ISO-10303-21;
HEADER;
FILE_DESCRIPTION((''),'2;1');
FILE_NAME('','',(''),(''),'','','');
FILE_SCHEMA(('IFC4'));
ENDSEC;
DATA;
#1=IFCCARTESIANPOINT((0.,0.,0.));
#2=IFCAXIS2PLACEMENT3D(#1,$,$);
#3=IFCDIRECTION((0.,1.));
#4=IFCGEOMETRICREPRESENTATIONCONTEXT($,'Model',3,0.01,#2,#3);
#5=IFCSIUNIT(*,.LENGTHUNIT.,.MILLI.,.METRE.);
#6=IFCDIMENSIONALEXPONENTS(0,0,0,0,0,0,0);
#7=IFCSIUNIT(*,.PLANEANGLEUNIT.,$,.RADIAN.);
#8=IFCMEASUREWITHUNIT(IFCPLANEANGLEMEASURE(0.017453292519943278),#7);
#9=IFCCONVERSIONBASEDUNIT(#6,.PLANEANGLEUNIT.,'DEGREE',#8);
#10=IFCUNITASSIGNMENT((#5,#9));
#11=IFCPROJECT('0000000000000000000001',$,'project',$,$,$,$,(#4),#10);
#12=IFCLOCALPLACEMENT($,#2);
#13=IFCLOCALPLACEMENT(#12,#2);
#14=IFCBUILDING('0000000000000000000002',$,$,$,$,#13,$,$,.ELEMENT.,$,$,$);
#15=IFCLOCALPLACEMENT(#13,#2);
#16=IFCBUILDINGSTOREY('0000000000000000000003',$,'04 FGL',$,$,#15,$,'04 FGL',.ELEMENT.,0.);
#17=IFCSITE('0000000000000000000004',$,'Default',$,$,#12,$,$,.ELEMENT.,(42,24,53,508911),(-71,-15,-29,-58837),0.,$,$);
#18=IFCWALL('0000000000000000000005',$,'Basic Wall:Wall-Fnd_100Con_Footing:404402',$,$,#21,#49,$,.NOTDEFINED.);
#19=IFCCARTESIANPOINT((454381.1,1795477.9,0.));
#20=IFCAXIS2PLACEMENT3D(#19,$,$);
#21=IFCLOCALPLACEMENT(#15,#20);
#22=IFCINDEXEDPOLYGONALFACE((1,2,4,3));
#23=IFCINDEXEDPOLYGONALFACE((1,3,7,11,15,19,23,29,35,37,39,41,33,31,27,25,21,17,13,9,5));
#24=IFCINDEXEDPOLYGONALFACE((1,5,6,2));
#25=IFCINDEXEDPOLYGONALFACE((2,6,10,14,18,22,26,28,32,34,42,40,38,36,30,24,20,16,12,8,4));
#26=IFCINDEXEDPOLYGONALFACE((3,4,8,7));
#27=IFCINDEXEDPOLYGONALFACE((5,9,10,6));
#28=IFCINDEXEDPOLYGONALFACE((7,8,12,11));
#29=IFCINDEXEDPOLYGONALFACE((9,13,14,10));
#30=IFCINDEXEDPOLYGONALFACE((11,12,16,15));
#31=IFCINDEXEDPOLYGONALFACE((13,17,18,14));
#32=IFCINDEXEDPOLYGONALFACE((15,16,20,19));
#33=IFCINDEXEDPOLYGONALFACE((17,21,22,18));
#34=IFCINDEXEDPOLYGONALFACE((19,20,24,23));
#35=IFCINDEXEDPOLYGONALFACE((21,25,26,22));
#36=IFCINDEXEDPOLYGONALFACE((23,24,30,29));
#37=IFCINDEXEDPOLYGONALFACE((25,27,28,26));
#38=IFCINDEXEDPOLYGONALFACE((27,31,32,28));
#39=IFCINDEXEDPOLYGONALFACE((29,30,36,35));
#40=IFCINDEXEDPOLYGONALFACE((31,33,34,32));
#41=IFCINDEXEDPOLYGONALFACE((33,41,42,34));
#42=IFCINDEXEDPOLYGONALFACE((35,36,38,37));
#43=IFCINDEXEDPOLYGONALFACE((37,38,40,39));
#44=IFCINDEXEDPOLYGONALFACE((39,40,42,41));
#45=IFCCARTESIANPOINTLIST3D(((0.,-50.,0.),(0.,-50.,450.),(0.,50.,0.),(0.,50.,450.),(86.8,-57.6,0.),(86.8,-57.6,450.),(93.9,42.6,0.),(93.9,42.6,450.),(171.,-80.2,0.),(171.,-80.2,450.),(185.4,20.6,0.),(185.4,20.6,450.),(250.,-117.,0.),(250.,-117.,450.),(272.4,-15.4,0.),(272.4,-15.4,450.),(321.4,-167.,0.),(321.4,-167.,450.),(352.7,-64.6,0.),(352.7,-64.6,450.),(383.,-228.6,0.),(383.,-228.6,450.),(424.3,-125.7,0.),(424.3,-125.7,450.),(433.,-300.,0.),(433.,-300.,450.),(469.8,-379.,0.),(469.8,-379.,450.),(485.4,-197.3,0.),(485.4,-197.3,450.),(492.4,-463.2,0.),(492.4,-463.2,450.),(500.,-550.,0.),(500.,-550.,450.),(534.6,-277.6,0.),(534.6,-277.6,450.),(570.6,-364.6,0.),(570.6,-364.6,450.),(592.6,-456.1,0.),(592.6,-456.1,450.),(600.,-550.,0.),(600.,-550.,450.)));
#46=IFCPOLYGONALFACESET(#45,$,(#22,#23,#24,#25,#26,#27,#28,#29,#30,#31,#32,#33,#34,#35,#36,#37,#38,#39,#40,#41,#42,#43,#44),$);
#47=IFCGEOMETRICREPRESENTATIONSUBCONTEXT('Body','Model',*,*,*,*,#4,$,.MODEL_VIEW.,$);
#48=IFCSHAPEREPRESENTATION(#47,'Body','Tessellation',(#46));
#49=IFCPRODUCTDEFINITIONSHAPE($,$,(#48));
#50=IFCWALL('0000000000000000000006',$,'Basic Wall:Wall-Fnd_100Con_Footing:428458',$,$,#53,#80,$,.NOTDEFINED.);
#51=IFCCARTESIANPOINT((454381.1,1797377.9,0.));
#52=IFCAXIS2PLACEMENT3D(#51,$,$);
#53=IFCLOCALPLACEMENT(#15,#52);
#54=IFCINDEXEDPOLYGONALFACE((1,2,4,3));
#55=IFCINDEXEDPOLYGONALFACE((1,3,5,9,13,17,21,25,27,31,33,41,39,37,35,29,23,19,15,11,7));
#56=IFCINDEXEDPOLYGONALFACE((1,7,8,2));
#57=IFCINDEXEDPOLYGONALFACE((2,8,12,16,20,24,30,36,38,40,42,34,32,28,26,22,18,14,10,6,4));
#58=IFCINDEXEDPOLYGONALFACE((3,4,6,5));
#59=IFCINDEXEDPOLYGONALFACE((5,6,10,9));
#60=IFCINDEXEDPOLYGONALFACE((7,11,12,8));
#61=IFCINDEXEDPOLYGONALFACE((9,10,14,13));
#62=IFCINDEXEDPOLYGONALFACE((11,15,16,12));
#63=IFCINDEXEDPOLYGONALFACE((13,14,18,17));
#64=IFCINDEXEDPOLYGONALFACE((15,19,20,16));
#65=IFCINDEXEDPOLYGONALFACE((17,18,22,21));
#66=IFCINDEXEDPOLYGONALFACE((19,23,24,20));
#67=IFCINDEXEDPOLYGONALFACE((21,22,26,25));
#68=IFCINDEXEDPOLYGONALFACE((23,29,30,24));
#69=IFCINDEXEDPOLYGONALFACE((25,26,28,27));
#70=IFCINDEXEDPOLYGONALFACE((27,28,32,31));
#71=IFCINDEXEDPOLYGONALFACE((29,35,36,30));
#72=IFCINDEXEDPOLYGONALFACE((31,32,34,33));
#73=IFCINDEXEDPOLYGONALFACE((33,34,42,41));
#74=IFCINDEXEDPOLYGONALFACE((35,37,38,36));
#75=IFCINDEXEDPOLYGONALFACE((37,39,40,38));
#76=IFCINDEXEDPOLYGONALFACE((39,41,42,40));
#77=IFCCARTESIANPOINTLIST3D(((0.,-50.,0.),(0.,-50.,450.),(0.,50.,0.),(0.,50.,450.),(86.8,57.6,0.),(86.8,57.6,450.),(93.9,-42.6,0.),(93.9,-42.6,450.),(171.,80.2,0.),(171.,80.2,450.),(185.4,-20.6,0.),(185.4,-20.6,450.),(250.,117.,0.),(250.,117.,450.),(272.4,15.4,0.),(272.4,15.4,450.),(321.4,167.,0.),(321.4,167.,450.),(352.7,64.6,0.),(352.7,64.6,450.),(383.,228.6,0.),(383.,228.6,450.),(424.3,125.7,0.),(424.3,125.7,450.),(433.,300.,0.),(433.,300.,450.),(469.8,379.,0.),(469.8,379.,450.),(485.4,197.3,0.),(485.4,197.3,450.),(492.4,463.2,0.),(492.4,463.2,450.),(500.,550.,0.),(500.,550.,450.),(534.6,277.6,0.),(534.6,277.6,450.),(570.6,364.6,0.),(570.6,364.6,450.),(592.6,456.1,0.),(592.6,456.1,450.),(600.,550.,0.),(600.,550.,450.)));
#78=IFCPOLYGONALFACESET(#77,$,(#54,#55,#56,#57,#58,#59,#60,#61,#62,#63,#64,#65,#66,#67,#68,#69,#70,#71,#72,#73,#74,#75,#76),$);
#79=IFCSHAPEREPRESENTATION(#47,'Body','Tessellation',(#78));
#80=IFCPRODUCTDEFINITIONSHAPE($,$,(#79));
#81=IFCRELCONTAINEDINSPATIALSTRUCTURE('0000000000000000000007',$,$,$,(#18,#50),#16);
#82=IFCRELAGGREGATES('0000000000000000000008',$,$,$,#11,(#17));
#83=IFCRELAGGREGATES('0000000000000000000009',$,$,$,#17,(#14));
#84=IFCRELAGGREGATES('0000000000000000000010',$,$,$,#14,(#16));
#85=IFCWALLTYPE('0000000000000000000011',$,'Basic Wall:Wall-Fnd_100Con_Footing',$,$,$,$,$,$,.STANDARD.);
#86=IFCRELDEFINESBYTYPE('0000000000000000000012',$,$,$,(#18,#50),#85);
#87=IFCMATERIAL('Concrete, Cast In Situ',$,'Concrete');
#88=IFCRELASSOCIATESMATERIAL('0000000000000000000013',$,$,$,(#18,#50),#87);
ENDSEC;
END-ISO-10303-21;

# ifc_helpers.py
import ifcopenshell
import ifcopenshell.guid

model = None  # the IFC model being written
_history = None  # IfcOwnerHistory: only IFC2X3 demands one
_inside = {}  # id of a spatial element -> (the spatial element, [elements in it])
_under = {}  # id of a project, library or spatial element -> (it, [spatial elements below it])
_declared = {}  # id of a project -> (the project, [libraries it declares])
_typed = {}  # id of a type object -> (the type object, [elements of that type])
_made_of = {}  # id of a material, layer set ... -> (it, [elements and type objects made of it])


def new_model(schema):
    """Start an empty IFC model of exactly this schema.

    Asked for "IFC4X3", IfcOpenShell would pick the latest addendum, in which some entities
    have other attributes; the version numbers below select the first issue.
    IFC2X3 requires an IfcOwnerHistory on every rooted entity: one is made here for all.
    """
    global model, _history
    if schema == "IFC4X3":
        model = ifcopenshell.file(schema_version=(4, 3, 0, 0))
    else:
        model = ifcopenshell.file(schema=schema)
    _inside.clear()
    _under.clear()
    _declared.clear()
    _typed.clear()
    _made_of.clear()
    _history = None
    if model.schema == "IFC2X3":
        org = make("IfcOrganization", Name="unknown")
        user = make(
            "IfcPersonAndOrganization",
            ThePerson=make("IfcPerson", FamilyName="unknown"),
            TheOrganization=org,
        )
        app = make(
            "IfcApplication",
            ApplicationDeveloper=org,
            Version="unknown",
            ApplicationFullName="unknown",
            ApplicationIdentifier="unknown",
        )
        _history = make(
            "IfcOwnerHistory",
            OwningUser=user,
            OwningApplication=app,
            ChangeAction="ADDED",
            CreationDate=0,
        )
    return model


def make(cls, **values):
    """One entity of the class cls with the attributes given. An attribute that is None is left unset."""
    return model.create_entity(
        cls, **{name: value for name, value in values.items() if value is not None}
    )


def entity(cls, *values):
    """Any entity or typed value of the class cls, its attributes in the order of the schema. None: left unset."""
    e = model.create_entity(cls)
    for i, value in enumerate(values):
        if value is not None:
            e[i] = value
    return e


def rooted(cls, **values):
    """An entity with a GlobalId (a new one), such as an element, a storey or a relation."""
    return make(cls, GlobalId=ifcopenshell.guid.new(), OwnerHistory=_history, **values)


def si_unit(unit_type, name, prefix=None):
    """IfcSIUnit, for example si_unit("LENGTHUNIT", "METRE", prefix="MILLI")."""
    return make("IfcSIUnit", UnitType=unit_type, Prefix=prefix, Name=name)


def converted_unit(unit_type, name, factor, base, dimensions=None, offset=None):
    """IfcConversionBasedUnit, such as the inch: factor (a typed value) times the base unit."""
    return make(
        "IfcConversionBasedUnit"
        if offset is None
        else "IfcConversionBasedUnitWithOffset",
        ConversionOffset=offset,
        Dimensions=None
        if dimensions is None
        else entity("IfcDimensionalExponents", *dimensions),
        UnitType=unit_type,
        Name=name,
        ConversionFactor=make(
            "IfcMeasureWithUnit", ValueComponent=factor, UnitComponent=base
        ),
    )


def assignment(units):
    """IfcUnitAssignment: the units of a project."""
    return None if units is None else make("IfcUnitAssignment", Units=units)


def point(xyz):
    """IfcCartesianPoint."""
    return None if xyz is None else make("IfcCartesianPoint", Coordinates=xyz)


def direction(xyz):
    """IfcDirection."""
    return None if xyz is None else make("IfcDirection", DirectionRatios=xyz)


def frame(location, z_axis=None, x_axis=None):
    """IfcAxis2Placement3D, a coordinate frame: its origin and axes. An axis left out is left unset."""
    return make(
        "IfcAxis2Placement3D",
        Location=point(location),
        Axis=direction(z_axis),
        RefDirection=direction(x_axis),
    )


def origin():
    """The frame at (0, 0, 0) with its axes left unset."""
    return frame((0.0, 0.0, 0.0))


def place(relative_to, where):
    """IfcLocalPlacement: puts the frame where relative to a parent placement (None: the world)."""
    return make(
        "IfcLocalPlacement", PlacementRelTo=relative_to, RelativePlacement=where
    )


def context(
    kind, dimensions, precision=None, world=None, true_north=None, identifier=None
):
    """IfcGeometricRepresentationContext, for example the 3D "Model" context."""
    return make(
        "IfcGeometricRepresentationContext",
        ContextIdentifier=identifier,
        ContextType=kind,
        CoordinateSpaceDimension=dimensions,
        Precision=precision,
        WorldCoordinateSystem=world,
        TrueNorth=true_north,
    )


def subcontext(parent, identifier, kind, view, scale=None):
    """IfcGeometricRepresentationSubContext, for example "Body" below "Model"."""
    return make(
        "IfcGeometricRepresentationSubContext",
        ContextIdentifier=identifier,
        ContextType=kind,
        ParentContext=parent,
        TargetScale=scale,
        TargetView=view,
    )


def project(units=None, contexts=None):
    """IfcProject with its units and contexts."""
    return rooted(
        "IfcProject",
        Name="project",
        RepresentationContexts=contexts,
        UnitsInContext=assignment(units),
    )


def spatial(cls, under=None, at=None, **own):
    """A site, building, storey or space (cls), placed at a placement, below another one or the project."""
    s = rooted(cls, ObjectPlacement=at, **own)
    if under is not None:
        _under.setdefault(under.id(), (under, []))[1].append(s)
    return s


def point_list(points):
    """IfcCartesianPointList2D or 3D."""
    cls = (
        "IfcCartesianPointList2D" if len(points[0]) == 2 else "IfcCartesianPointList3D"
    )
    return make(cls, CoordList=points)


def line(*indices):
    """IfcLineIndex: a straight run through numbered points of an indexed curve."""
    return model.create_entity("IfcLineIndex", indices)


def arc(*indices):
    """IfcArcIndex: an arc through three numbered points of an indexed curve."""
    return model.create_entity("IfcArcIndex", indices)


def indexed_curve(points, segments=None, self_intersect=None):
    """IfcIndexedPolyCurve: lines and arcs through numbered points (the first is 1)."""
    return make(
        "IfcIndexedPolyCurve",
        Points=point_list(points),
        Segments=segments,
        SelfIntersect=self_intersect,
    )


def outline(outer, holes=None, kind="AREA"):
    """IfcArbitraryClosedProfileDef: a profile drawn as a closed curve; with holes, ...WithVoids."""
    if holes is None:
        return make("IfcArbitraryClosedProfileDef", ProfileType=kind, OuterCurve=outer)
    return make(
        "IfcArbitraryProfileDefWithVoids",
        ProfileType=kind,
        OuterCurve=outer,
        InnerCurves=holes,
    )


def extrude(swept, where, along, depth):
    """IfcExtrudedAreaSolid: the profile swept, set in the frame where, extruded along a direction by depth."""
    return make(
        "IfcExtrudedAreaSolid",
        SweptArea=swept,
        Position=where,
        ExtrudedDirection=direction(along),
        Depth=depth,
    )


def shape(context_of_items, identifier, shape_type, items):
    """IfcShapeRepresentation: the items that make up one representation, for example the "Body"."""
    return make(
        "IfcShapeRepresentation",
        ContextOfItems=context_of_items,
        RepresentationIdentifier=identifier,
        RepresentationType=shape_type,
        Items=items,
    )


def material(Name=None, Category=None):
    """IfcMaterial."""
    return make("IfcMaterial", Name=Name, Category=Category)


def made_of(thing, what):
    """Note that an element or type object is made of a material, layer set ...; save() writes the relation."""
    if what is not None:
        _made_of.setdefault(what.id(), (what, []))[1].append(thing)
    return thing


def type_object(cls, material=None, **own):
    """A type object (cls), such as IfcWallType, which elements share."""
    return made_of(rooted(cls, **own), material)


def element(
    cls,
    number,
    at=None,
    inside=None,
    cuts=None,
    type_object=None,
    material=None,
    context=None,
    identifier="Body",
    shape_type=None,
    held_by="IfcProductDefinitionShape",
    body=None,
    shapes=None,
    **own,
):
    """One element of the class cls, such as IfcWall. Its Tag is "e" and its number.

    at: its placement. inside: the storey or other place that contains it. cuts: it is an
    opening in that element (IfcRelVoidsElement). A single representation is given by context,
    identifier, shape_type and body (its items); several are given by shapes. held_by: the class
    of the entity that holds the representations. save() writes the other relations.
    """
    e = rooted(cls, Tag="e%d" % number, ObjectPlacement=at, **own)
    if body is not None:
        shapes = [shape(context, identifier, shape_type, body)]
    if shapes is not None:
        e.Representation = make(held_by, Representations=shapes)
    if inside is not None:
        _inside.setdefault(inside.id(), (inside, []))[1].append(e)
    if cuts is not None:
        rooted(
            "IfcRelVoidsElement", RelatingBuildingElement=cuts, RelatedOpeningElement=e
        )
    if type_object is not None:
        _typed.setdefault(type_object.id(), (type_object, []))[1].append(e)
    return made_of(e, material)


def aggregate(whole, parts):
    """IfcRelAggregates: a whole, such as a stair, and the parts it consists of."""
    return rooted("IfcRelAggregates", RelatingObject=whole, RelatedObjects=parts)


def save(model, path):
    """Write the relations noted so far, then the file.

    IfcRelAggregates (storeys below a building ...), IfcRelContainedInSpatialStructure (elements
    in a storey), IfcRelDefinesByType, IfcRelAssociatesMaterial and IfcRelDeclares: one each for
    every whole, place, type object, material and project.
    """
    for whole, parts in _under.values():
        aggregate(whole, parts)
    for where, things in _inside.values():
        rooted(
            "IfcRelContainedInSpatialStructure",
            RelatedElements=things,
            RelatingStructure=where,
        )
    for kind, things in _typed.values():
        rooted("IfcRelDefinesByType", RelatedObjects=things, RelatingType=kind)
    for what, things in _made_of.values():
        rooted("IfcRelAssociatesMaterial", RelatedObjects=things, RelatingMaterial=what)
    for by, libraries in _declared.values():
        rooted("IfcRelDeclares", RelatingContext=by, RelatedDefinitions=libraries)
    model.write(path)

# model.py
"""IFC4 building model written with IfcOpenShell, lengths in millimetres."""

from ifc_helpers import new_model, entity, si_unit, converted_unit, direction, frame, origin, place, context, subcontext, project, spatial, line, arc, indexed_curve, outline, extrude, material, type_object, element, save


model = new_model("IFC4")

# Units and contexts
model_context = context("Model", 3, precision=0.01, world=origin(), true_north=direction((0.0, 1.0)))
body_context = subcontext(model_context, "Body", "Model", "MODEL_VIEW")
ifc_project = project(units=[si_unit("LENGTHUNIT", "METRE", prefix="MILLI"), converted_unit("PLANEANGLEUNIT", "DEGREE", entity("IfcPlaneAngleMeasure", 0.017453292519943278), si_unit("PLANEANGLEUNIT", "RADIAN"), dimensions=[0, 0, 0, 0, 0, 0, 0])], contexts=[model_context])

# Site, building, storey
site_placement = place(None, origin())
site = spatial("IfcSite", under=ifc_project, at=site_placement, Name="Default", CompositionType="ELEMENT", RefLatitude=(42, 24, 53, 508911), RefLongitude=(-71, -15, -29, -58837), RefElevation=0.0)
building_placement = place(site_placement, origin())
building = spatial("IfcBuilding", under=site, at=building_placement, CompositionType="ELEMENT")
storey_placement = place(building_placement, origin())
storey = spatial("IfcBuildingStorey", under=building, at=storey_placement, Name="04 FGL", LongName="04 FGL", CompositionType="ELEMENT", Elevation=0.0)

# Walls
ifc_material_1 = material(Name="Concrete, Cast In Situ", Category="Concrete")
wall_type_1 = type_object("IfcWallType", Name="Basic Wall:Wall-Fnd_100Con_Footing", PredefinedType="STANDARD")
wall_1_placement = place(storey_placement, frame((454381.1, 1795477.9, 0.0)))
element("IfcWall", 1, at=wall_1_placement, inside=storey, type_object=wall_type_1, material=ifc_material_1, Name="Basic Wall:Wall-Fnd_100Con_Footing:404402", PredefinedType="NOTDEFINED", context=body_context, shape_type="SweptSolid", body=[
    extrude(outline(indexed_curve([(600.0, -550.0), (424.3, -125.7), (0.0, 50.0), (0.0, -50.0), (353.6, -196.4), (500.0, -550.0)], segments=[arc(1, 2, 3), line(3, 4), arc(4, 5, 6), line(6, 1)], self_intersect=False)), origin(), (0.0, 0.0, 1.0), 450.0),
])
wall_2_placement = place(storey_placement, frame((454381.1, 1797377.9, 0.0)))
element("IfcWall", 2, at=wall_2_placement, inside=storey, type_object=wall_type_1, material=ifc_material_1, Name="Basic Wall:Wall-Fnd_100Con_Footing:428458", PredefinedType="NOTDEFINED", context=body_context, shape_type="SweptSolid", body=[
    extrude(outline(indexed_curve([(500.0, 550.0), (353.6, 196.4), (0.0, 50.0), (0.0, -50.0), (424.3, 125.7), (600.0, 550.0)], segments=[arc(1, 2, 3), line(3, 4), arc(4, 5, 6), line(6, 1)], self_intersect=False)), origin(), (0.0, 0.0, 1.0), 450.0),
])

save(model, "model.ifc")
